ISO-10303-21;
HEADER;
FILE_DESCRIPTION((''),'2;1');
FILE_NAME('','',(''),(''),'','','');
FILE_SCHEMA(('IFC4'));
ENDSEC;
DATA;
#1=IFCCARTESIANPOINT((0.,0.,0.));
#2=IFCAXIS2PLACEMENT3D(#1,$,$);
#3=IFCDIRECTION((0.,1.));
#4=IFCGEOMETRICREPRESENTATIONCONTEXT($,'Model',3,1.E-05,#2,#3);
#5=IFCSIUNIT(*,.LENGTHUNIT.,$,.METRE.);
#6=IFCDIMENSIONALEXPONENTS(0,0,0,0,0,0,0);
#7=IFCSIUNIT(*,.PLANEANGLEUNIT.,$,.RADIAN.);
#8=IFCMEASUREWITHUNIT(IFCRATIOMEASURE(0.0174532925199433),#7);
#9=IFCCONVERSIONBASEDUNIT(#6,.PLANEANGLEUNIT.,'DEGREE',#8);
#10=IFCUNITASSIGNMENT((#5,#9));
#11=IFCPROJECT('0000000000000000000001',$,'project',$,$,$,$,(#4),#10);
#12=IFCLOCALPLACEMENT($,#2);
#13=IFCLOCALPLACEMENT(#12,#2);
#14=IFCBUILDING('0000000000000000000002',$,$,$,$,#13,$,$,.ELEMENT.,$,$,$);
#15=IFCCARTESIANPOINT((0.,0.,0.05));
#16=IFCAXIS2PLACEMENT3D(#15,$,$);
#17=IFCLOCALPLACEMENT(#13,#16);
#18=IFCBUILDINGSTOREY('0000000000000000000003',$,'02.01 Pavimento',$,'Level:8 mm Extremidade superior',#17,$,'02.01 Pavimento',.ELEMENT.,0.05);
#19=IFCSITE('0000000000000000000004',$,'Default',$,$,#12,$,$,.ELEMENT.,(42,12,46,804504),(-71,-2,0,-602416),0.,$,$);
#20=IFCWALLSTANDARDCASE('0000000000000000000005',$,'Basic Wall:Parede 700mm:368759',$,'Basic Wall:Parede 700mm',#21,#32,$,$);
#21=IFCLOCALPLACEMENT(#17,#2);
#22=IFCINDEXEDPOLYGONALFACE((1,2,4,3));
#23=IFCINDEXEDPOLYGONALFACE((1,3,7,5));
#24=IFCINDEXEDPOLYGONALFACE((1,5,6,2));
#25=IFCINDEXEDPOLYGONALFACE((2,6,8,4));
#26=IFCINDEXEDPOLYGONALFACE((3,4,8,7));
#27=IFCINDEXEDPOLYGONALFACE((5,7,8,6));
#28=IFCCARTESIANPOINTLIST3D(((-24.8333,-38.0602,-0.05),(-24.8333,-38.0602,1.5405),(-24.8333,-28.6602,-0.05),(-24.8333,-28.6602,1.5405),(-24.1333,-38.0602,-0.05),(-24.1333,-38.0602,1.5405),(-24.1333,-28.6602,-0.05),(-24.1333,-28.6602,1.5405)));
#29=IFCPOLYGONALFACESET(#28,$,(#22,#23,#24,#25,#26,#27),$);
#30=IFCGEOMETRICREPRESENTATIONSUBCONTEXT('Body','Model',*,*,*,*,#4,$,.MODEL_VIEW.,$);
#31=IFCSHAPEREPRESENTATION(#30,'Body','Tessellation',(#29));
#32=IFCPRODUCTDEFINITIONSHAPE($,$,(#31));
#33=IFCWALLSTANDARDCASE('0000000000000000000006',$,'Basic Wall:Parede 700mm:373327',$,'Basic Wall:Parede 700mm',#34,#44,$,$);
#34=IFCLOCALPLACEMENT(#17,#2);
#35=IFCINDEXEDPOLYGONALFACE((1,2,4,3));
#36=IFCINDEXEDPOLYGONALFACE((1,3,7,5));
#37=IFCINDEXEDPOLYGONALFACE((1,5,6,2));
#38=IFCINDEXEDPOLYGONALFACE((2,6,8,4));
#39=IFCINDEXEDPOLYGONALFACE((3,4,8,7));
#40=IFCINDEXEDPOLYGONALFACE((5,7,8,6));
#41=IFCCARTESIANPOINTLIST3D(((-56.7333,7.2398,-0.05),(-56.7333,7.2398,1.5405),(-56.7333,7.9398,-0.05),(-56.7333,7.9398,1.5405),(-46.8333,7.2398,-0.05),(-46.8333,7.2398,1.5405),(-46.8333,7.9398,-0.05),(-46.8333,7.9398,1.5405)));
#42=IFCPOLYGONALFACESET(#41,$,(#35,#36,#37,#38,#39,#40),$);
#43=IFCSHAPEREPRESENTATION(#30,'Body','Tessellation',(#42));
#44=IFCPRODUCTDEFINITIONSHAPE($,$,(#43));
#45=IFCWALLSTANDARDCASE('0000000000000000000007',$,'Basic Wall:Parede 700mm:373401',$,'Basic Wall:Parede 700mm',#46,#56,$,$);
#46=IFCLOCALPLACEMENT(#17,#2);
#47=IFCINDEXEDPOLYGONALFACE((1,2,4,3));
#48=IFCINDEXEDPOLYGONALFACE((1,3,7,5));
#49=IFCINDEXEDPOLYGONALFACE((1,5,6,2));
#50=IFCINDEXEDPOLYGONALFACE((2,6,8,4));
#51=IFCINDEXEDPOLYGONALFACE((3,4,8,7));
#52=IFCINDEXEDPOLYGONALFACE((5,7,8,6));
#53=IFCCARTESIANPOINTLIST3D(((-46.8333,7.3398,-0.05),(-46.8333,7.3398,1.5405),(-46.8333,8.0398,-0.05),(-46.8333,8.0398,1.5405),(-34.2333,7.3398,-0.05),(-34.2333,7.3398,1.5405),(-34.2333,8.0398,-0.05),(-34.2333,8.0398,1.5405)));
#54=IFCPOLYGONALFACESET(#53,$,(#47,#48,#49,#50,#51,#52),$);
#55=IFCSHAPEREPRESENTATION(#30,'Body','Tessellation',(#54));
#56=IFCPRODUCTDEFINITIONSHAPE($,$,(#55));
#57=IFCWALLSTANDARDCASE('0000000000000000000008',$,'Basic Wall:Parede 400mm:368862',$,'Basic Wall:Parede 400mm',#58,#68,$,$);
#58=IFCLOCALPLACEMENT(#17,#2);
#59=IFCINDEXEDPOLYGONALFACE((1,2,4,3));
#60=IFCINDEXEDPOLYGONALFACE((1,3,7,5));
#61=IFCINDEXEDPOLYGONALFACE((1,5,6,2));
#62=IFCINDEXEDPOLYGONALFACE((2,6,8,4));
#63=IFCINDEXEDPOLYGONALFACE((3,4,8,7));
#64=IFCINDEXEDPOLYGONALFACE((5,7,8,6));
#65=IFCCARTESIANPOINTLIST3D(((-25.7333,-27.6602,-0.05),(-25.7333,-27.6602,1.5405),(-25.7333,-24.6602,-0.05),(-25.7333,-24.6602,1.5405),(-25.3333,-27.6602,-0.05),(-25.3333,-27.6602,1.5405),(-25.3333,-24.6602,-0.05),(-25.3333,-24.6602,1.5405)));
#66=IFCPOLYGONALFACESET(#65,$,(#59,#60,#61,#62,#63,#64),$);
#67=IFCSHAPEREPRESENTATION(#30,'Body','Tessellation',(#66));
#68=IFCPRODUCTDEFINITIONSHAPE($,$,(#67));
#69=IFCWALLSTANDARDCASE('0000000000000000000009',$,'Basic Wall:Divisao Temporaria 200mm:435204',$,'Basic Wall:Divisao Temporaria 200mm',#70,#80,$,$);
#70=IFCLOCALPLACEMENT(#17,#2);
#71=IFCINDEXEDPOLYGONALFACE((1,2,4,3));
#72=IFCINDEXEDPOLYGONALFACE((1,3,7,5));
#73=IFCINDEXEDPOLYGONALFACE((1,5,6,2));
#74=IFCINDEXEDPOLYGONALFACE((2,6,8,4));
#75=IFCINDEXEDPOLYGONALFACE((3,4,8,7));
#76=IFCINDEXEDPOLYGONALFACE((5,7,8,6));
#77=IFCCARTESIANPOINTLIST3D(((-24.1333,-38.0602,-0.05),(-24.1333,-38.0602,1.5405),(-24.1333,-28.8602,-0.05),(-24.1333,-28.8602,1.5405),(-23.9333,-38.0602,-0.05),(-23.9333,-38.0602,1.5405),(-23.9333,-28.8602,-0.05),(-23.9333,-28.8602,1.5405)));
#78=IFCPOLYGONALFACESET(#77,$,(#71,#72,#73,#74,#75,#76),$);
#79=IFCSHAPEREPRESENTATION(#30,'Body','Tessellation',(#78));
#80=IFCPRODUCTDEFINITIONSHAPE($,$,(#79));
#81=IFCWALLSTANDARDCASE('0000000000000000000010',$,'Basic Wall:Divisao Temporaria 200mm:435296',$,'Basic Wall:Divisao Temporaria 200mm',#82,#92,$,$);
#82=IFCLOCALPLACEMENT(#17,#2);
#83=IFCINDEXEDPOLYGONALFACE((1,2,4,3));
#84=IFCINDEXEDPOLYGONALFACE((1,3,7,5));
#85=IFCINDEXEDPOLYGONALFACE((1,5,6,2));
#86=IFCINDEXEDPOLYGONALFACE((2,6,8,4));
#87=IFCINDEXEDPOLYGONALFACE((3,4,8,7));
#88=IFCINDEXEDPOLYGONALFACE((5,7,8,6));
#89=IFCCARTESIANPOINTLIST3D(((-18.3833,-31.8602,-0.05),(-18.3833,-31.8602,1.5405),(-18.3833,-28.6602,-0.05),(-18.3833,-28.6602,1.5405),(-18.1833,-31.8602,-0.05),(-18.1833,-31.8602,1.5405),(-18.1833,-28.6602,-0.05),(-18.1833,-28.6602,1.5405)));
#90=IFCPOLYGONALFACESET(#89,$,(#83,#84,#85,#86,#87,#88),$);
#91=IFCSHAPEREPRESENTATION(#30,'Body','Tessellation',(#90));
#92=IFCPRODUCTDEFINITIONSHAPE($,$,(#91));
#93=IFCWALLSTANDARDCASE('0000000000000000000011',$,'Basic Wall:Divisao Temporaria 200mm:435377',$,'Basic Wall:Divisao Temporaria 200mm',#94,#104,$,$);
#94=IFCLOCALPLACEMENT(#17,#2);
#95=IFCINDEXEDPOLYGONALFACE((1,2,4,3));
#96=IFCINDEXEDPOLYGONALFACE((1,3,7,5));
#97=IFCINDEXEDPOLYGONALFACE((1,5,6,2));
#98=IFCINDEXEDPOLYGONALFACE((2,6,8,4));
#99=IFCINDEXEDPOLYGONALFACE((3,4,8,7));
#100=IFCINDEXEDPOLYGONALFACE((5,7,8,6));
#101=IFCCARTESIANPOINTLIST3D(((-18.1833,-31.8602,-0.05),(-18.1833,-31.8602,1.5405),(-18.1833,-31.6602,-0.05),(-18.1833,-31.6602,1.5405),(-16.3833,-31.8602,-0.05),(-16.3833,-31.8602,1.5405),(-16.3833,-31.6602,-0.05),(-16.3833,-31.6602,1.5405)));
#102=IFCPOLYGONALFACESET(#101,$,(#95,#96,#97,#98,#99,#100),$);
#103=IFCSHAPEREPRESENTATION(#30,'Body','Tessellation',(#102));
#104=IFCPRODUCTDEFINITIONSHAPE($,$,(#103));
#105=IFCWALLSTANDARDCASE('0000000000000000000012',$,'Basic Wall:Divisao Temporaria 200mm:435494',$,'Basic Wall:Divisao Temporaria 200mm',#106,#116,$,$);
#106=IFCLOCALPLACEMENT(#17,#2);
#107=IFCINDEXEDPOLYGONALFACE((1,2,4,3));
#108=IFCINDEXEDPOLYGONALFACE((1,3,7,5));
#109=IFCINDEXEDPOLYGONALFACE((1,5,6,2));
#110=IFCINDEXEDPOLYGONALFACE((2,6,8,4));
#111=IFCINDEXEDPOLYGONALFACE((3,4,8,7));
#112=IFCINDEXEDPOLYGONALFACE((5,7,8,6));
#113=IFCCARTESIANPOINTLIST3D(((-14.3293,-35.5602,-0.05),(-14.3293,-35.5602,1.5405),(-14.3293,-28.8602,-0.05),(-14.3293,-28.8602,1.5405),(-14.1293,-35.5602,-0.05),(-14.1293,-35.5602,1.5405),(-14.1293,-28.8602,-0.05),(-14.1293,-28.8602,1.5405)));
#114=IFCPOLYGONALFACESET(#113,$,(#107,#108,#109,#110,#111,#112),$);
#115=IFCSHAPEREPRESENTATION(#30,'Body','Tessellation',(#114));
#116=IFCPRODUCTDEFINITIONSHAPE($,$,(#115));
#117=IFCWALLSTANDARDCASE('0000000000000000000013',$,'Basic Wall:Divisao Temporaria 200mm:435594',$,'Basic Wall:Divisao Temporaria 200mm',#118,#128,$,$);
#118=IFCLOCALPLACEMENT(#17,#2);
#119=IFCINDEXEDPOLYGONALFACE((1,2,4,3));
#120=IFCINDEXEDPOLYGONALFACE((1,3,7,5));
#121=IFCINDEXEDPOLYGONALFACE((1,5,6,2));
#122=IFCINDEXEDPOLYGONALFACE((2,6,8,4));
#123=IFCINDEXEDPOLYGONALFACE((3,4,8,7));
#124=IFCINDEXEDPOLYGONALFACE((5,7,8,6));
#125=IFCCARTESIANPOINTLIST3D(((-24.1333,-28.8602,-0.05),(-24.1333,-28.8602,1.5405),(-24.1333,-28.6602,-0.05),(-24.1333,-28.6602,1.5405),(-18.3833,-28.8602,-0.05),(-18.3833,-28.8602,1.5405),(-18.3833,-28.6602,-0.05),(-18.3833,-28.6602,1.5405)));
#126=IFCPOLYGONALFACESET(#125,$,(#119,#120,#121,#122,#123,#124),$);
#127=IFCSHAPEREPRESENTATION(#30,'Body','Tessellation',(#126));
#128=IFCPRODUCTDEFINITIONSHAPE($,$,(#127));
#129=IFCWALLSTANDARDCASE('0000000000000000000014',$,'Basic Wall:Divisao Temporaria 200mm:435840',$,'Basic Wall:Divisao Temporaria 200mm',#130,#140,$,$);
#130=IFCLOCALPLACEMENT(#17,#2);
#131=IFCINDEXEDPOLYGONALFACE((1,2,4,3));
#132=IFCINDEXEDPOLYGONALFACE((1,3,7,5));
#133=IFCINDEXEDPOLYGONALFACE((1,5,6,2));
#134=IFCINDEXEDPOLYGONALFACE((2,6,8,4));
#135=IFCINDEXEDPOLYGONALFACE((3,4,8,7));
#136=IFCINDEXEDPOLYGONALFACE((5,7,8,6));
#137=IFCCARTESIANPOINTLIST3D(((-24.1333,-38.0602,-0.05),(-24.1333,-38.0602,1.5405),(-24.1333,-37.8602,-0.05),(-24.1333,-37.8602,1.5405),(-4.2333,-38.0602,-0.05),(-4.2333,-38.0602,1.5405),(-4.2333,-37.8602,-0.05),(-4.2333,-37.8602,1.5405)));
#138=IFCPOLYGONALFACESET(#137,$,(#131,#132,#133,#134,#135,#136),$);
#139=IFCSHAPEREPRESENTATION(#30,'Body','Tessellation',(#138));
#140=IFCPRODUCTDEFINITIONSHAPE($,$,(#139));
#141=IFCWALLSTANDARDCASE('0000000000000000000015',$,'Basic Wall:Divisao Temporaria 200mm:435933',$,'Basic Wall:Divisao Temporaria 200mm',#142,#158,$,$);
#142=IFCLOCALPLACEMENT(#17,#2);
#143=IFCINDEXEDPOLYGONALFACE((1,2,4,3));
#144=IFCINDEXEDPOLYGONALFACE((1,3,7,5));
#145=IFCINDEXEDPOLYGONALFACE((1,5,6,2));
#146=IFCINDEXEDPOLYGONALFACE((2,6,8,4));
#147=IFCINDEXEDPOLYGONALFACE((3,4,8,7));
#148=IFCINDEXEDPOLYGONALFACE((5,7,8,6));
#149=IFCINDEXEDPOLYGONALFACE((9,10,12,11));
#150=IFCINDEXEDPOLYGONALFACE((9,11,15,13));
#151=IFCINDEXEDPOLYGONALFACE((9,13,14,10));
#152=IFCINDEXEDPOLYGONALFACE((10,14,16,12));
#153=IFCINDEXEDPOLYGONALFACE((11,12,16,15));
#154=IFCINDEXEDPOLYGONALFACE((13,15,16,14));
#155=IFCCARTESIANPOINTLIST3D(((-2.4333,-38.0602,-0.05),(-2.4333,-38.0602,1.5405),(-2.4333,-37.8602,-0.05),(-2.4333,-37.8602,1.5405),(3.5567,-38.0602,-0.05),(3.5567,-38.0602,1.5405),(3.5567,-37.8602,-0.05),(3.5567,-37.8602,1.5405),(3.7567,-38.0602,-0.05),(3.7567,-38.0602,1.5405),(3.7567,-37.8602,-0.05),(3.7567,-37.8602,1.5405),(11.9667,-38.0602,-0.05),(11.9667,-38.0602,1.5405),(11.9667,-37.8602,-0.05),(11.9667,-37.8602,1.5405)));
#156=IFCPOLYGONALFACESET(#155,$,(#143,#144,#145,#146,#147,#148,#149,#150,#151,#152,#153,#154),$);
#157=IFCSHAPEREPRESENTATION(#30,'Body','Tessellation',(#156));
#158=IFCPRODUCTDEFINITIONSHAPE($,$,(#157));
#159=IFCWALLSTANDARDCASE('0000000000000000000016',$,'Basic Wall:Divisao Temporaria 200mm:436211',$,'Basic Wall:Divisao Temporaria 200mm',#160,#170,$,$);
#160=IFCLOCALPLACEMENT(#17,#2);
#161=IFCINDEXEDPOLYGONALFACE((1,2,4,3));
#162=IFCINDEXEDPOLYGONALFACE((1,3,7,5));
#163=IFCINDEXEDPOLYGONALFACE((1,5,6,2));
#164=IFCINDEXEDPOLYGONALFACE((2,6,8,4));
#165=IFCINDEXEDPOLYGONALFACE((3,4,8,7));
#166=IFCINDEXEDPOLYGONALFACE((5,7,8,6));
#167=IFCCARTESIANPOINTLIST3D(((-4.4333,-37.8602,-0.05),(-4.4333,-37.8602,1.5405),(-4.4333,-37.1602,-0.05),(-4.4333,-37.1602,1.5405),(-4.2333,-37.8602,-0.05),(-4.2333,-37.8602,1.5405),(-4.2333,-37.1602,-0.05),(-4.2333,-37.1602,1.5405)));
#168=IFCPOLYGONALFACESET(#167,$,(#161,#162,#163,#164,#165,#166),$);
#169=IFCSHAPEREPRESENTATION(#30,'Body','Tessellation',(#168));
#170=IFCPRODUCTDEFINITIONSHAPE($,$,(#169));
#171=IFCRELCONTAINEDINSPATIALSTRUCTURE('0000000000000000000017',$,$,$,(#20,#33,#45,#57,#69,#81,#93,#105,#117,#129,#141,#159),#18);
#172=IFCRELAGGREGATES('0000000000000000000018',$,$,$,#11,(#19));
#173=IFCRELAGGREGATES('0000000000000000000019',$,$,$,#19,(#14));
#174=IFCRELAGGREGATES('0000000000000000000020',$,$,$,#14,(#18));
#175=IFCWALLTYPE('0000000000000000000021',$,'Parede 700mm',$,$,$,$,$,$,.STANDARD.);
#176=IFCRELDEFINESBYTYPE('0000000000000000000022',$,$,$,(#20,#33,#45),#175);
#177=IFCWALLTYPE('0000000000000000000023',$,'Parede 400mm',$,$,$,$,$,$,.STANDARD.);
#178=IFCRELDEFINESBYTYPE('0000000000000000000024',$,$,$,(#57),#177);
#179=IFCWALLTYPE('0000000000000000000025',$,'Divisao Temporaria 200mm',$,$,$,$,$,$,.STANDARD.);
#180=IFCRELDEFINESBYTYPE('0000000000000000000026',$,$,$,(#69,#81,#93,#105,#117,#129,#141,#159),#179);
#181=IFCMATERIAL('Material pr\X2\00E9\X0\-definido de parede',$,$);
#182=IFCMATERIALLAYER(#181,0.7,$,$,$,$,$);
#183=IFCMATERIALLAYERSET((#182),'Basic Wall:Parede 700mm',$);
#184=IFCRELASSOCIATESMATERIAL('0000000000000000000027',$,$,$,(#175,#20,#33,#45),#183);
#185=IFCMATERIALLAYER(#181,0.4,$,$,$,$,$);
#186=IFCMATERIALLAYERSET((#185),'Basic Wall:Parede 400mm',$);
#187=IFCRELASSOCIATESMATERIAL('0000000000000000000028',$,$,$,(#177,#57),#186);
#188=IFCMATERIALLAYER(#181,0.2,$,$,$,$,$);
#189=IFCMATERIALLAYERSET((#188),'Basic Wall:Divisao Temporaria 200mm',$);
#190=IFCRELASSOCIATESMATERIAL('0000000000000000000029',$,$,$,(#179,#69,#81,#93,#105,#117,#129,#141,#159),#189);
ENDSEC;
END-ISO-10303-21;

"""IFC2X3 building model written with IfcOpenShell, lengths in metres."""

from ifc_helpers import new_model, entity, si_unit, converted_unit, direction, frame, frame_2d, origin, origin_2d_with_axis, place, context, subcontext, project, spatial, rectangle, extrude, clip, halfspace, material, layer, layer_set, layer_usage, type_object, element, save


model = new_model("IFC2X3")

# Units and contexts
model_context = context("Model", 3, precision=1e-05, world=origin(), true_north=direction((0.0, 1.0)))
body_context = subcontext(model_context, "Body", "Model", "MODEL_VIEW")
ifc_project = project(units=[si_unit("LENGTHUNIT", "METRE"), converted_unit("PLANEANGLEUNIT", "DEGREE", entity("IfcRatioMeasure", 0.0174532925199433), si_unit("PLANEANGLEUNIT", "RADIAN"), dimensions=[0, 0, 0, 0, 0, 0, 0])], contexts=[model_context])

# Site, building, storey
site_placement = place(None, origin())
site = spatial("IfcSite", under=ifc_project, at=site_placement, Name="Default", CompositionType="ELEMENT", RefLatitude=(42, 12, 46, 804504), RefLongitude=(-71, -2, 0, -602416), RefElevation=0.0)
building_placement = place(site_placement, origin())
building = spatial("IfcBuilding", under=site, at=building_placement, CompositionType="ELEMENT")
storey_placement = place(building_placement, frame((0.0, 0.0, 0.05)))
storey = spatial("IfcBuildingStorey", under=building, at=storey_placement, Name="02.01 Pavimento", ObjectType="Level:8 mm Extremidade superior", LongName="02.01 Pavimento", CompositionType="ELEMENT", Elevation=0.05)

# Shared definitions
ifc_material_1 = material(Name="Material pré-definido de parede")

# Walls
ifc_layer_1 = layer(ifc_material_1, 0.7)
ifc_layer_set_1 = layer_set([ifc_layer_1], Name="Basic Wall:Parede 700mm")
ifc_layer_usage_1 = layer_usage(ifc_layer_set_1, "AXIS2", "POSITIVE", -0.35)
wall_type_1 = type_object("IfcWallType", Name="Parede 700mm", PredefinedType="STANDARD", material=ifc_layer_set_1)
wall_1_placement = place(storey_placement, frame((-24.4833, -38.0602, -0.05), z_axis=(0.0, 0.0, 1.0), x_axis=(0.0, 1.0, 0.0)))
element("IfcWallStandardCase", 1, at=wall_1_placement, inside=storey, type_object=wall_type_1, material=ifc_layer_usage_1, Name="Basic Wall:Parede 700mm:368759", ObjectType="Basic Wall:Parede 700mm", context=body_context, shape_type="Clipping", body=[
    clip(extrude(rectangle(XDim=9.4, YDim=0.7, at=frame_2d((4.7, 0.0), x_axis=(-1.0, 0.0))), origin(), (0.0, 0.0, 1.0), 1.5905), halfspace(frame((0.0, 0.0, -0.05)), True)),
])
ifc_layer_usage_2 = layer_usage(ifc_layer_set_1, "AXIS2", "NEGATIVE", 0.35)
wall_2_placement = place(storey_placement, frame((-56.7333, 7.5898, -0.05)))
element("IfcWallStandardCase", 2, at=wall_2_placement, inside=storey, type_object=wall_type_1, material=ifc_layer_usage_2, Name="Basic Wall:Parede 700mm:373327", ObjectType="Basic Wall:Parede 700mm", context=body_context, shape_type="Clipping", body=[
    clip(extrude(rectangle(XDim=9.9, YDim=0.7, at=frame_2d((4.95, 0.0), x_axis=(-1.0, 0.0))), origin(), (0.0, 0.0, 1.0), 1.5905), halfspace(frame((0.0, 0.0, -0.05)), True)),
])
ifc_layer_usage_3 = layer_usage(ifc_layer_set_1, "AXIS2", "NEGATIVE", 0.35)
wall_3_placement = place(storey_placement, frame((-46.8333, 7.6898, -0.05)))
element("IfcWallStandardCase", 3, at=wall_3_placement, inside=storey, type_object=wall_type_1, material=ifc_layer_usage_3, Name="Basic Wall:Parede 700mm:373401", ObjectType="Basic Wall:Parede 700mm", context=body_context, shape_type="Clipping", body=[
    clip(extrude(rectangle(XDim=12.6, YDim=0.7, at=frame_2d((6.3, 0.0), x_axis=(-1.0, 0.0))), origin(), (0.0, 0.0, 1.0), 1.5905), halfspace(frame((0.0, 0.0, -0.05)), True)),
])
ifc_layer_2 = layer(ifc_material_1, 0.4)
ifc_layer_set_2 = layer_set([ifc_layer_2], Name="Basic Wall:Parede 400mm")
ifc_layer_usage_4 = layer_usage(ifc_layer_set_2, "AXIS2", "NEGATIVE", 0.2)
wall_type_2 = type_object("IfcWallType", Name="Parede 400mm", PredefinedType="STANDARD", material=ifc_layer_set_2)
wall_4_placement = place(storey_placement, frame((-25.5333, -27.6602, -0.05), z_axis=(0.0, 0.0, 1.0), x_axis=(0.0, 1.0, 0.0)))
element("IfcWallStandardCase", 4, at=wall_4_placement, inside=storey, type_object=wall_type_2, material=ifc_layer_usage_4, Name="Basic Wall:Parede 400mm:368862", ObjectType="Basic Wall:Parede 400mm", context=body_context, shape_type="Clipping", body=[
    clip(extrude(rectangle(XDim=3.0, YDim=0.4, at=frame_2d((1.5, 0.0), x_axis=(-1.0, 0.0))), origin(), (0.0, 0.0, 1.0), 1.5905), halfspace(frame((0.0, 0.0, -0.05)), True)),
])
ifc_layer_3 = layer(ifc_material_1, 0.2)
ifc_layer_set_3 = layer_set([ifc_layer_3], Name="Basic Wall:Divisao Temporaria 200mm")
ifc_layer_usage_5 = layer_usage(ifc_layer_set_3, "AXIS2", "NEGATIVE", 0.1)
wall_type_3 = type_object("IfcWallType", Name="Divisao Temporaria 200mm", PredefinedType="STANDARD", material=ifc_layer_set_3)
wall_5_placement = place(storey_placement, frame((-24.0333, -38.0602, -0.05), z_axis=(0.0, 0.0, 1.0), x_axis=(0.0, 1.0, 0.0)))
element("IfcWallStandardCase", 5, at=wall_5_placement, inside=storey, type_object=wall_type_3, material=ifc_layer_usage_5, Name="Basic Wall:Divisao Temporaria 200mm:435204", ObjectType="Basic Wall:Divisao Temporaria 200mm", context=body_context, shape_type="Clipping", body=[
    clip(extrude(rectangle(XDim=9.2, YDim=0.2, at=frame_2d((4.6, 0.0), x_axis=(-1.0, 0.0))), origin(), (0.0, 0.0, 1.0), 1.5905), halfspace(frame((0.0, 0.0, -0.05)), True)),
])
ifc_layer_usage_6 = layer_usage(ifc_layer_set_3, "AXIS2", "NEGATIVE", 0.1)
wall_6_placement = place(storey_placement, frame((-18.2833, -28.6602, -0.05), z_axis=(0.0, 0.0, 1.0), x_axis=(0.0, -1.0, 0.0)))
element("IfcWallStandardCase", 6, at=wall_6_placement, inside=storey, type_object=wall_type_3, material=ifc_layer_usage_6, Name="Basic Wall:Divisao Temporaria 200mm:435296", ObjectType="Basic Wall:Divisao Temporaria 200mm", context=body_context, shape_type="Clipping", body=[
    clip(extrude(rectangle(XDim=3.2, YDim=0.2, at=frame_2d((1.6, 0.0), x_axis=(-1.0, 0.0))), origin(), (0.0, 0.0, 1.0), 1.5905), halfspace(frame((0.0, 0.0, -0.05)), True)),
])
ifc_layer_usage_7 = layer_usage(ifc_layer_set_3, "AXIS2", "POSITIVE", -0.1)
wall_7_placement = place(storey_placement, frame((-18.1833, -31.7602, -0.05)))
element("IfcWallStandardCase", 7, at=wall_7_placement, inside=storey, type_object=wall_type_3, material=ifc_layer_usage_7, Name="Basic Wall:Divisao Temporaria 200mm:435377", ObjectType="Basic Wall:Divisao Temporaria 200mm", context=body_context, shape_type="Clipping", body=[
    clip(extrude(rectangle(XDim=1.8, YDim=0.2, at=frame_2d((0.9, 0.0), x_axis=(-1.0, 0.0))), origin(), (0.0, 0.0, 1.0), 1.5905), halfspace(frame((0.0, 0.0, -0.05)), True)),
])
ifc_layer_usage_8 = layer_usage(ifc_layer_set_3, "AXIS2", "POSITIVE", -0.1)
wall_8_placement = place(storey_placement, frame((-14.2293, -28.8602, -0.05), z_axis=(0.0, 0.0, 1.0), x_axis=(0.0, -1.0, 0.0)))
element("IfcWallStandardCase", 8, at=wall_8_placement, inside=storey, type_object=wall_type_3, material=ifc_layer_usage_8, Name="Basic Wall:Divisao Temporaria 200mm:435494", ObjectType="Basic Wall:Divisao Temporaria 200mm", context=body_context, shape_type="Clipping", body=[
    clip(extrude(rectangle(XDim=6.7, YDim=0.2, at=frame_2d((3.35, 0.0), x_axis=(-1.0, 0.0))), origin(), (0.0, 0.0, 1.0), 1.5905), halfspace(frame((0.0, 0.0, -0.05)), True)),
])
ifc_layer_usage_9 = layer_usage(ifc_layer_set_3, "AXIS2", "POSITIVE", -0.1)
wall_9_placement = place(storey_placement, frame((-18.3833, -28.7602, -0.05), z_axis=(0.0, 0.0, 1.0), x_axis=(-1.0, 0.0, 0.0)))
element("IfcWallStandardCase", 9, at=wall_9_placement, inside=storey, type_object=wall_type_3, material=ifc_layer_usage_9, Name="Basic Wall:Divisao Temporaria 200mm:435594", ObjectType="Basic Wall:Divisao Temporaria 200mm", context=body_context, shape_type="Clipping", body=[
    clip(extrude(rectangle(XDim=5.75, YDim=0.2, at=frame_2d((2.875, 0.0), x_axis=(-1.0, 0.0))), origin(), (0.0, 0.0, 1.0), 1.5905), halfspace(frame((0.0, 0.0, -0.05)), True)),
])
ifc_layer_usage_10 = layer_usage(ifc_layer_set_3, "AXIS2", "POSITIVE", -0.1)
wall_10_placement = place(storey_placement, frame((-24.1333, -37.9602, -0.05)))
element("IfcWallStandardCase", 10, at=wall_10_placement, inside=storey, type_object=wall_type_3, material=ifc_layer_usage_10, Name="Basic Wall:Divisao Temporaria 200mm:435840", ObjectType="Basic Wall:Divisao Temporaria 200mm", context=body_context, shape_type="Clipping", body=[
    clip(extrude(rectangle(XDim=19.9, YDim=0.2, at=frame_2d((9.95, 0.0), x_axis=(-1.0, 0.0))), origin(), (0.0, 0.0, 1.0), 1.5905), halfspace(frame((0.0, 0.0, -0.05)), True)),
])

# Wall, opening
ifc_layer_usage_11 = layer_usage(ifc_layer_set_3, "AXIS2", "POSITIVE", -0.1)
wall_11_placement = place(storey_placement, frame((-2.4333, -37.9602, -0.05)))
wall_11 = element("IfcWallStandardCase", 11, at=wall_11_placement, inside=storey, type_object=wall_type_3, material=ifc_layer_usage_11, Name="Basic Wall:Divisao Temporaria 200mm:435933", ObjectType="Basic Wall:Divisao Temporaria 200mm", context=body_context, shape_type="Clipping", body=[
    clip(extrude(rectangle(XDim=14.4, YDim=0.2, at=frame_2d((7.2, 0.0), x_axis=(-1.0, 0.0))), origin(), (0.0, 0.0, 1.0), 1.5905), halfspace(frame((0.0, 0.0, -0.05)), True)),
])
opening_1_placement = place(storey_placement, frame((-2.4333, -37.9602, -0.05)))
element("IfcOpeningElement", 12, at=opening_1_placement, cuts=wall_11, ObjectType="Opening", context=body_context, shape_type="SweptSolid", body=[
    extrude(rectangle(XDim=4.8, YDim=0.2, at=origin_2d_with_axis()), frame((5.99, 0.0, 2.4), z_axis=(1.0, 0.0, 0.0), x_axis=(0.0, 0.0, -1.0)), (0.0, 0.0, 1.0), 0.2),
])

# Wall
ifc_layer_usage_12 = layer_usage(ifc_layer_set_3, "AXIS2", "POSITIVE", -0.1)
wall_12_placement = place(storey_placement, frame((-4.3333, -37.8602, -0.05), z_axis=(0.0, 0.0, 1.0), x_axis=(0.0, 1.0, 0.0)))
element("IfcWallStandardCase", 13, at=wall_12_placement, inside=storey, type_object=wall_type_3, material=ifc_layer_usage_12, Name="Basic Wall:Divisao Temporaria 200mm:436211", ObjectType="Basic Wall:Divisao Temporaria 200mm", context=body_context, shape_type="Clipping", body=[
    clip(extrude(rectangle(XDim=0.7, YDim=0.2, at=frame_2d((0.35, 0.0), x_axis=(-1.0, 0.0))), origin(), (0.0, 0.0, 1.0), 1.5905), halfspace(frame((0.0, 0.0, -0.05)), True)),
])

save(model, "model.ifc")
